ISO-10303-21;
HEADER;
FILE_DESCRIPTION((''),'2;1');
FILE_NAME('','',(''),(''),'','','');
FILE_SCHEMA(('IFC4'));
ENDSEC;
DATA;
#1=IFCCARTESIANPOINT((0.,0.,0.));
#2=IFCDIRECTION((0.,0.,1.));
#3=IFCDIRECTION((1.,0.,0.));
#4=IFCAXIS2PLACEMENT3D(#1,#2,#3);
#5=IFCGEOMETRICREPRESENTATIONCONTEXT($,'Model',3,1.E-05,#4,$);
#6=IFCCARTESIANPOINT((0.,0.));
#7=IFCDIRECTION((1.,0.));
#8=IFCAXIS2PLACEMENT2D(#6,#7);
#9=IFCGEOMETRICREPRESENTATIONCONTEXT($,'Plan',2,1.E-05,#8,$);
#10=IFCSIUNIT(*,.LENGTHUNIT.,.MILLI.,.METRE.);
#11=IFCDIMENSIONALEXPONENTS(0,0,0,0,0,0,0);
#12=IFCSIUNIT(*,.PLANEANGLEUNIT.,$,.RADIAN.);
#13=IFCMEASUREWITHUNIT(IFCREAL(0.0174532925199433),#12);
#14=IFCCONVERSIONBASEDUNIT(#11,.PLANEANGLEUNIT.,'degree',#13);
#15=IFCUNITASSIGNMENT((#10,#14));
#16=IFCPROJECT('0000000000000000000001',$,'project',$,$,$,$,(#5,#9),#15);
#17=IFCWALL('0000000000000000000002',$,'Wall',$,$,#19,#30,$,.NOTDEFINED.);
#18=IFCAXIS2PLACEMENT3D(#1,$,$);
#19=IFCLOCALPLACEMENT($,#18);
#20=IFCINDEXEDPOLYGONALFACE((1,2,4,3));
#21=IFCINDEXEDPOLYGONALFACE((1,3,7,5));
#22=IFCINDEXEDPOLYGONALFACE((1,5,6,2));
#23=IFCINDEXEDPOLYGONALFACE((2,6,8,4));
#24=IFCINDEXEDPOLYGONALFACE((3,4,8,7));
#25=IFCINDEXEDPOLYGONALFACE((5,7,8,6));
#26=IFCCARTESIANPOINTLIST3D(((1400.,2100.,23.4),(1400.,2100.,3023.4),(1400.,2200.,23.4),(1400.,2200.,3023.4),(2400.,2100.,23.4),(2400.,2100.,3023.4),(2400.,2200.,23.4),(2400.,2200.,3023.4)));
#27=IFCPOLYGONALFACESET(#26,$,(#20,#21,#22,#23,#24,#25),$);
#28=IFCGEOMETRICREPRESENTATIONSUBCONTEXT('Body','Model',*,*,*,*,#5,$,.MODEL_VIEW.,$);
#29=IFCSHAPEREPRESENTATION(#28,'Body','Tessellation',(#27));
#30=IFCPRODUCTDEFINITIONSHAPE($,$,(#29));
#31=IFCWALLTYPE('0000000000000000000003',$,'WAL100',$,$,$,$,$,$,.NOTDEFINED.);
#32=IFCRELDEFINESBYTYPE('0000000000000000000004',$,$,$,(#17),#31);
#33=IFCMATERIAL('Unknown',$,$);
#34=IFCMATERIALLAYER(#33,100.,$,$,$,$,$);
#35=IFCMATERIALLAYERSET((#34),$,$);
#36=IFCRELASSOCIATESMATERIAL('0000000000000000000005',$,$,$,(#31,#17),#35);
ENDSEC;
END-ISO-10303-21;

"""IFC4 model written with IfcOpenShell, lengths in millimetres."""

from ifc_helpers import new_model, entity, si_unit, converted_unit, frame, origin_with_axes, origin_2d_with_axis, place, context, subcontext, project, indexed_curve, outline, extrude, material, layer, layer_set, layer_usage, type_object, element, save


model = new_model("IFC4")

# Units and contexts
model_context = context("Model", 3, precision=1e-05, world=origin_with_axes())
plan_context = context("Plan", 2, precision=1e-05, world=origin_2d_with_axis())
body_context = subcontext(model_context, "Body", "Model", "MODEL_VIEW")
ifc_project = project(units=[si_unit("LENGTHUNIT", "METRE", prefix="MILLI"), converted_unit("PLANEANGLEUNIT", "degree", entity("IfcReal", 0.0174532925199433), si_unit("PLANEANGLEUNIT", "RADIAN"), dimensions=[0, 0, 0, 0, 0, 0, 0])], contexts=[model_context, plan_context])

# Wall
ifc_material = material(Name="Unknown")
ifc_layer = layer(ifc_material, 100.0)
ifc_layer_set = layer_set([ifc_layer])
ifc_layer_usage = layer_usage(ifc_layer_set, "AXIS2", "POSITIVE", 0.0)
wall_type = type_object("IfcWallType", Name="WAL100", PredefinedType="NOTDEFINED", material=ifc_layer_set)
wall_placement = place(None, frame((1400.0, 2100.0, 23.4), z_axis=(0.0, 0.0, 1.0), x_axis=(1.0, 0.0, 0.0)))
element("IfcWall", 1, at=wall_placement, type_object=wall_type, material=ifc_layer_usage, Name="Wall", PredefinedType="NOTDEFINED", context=body_context, shape_type="SweptSolid", body=[
    extrude(outline(indexed_curve([(0.0, 0.0), (0.0, 100.0), (1000.0, 100.0), (1000.0, 0.0), (0.0, 0.0)], self_intersect=False)), origin_with_axes(), (0.0, 0.0, 1.0), 3000.0),
])

save(model, "model.ifc")
